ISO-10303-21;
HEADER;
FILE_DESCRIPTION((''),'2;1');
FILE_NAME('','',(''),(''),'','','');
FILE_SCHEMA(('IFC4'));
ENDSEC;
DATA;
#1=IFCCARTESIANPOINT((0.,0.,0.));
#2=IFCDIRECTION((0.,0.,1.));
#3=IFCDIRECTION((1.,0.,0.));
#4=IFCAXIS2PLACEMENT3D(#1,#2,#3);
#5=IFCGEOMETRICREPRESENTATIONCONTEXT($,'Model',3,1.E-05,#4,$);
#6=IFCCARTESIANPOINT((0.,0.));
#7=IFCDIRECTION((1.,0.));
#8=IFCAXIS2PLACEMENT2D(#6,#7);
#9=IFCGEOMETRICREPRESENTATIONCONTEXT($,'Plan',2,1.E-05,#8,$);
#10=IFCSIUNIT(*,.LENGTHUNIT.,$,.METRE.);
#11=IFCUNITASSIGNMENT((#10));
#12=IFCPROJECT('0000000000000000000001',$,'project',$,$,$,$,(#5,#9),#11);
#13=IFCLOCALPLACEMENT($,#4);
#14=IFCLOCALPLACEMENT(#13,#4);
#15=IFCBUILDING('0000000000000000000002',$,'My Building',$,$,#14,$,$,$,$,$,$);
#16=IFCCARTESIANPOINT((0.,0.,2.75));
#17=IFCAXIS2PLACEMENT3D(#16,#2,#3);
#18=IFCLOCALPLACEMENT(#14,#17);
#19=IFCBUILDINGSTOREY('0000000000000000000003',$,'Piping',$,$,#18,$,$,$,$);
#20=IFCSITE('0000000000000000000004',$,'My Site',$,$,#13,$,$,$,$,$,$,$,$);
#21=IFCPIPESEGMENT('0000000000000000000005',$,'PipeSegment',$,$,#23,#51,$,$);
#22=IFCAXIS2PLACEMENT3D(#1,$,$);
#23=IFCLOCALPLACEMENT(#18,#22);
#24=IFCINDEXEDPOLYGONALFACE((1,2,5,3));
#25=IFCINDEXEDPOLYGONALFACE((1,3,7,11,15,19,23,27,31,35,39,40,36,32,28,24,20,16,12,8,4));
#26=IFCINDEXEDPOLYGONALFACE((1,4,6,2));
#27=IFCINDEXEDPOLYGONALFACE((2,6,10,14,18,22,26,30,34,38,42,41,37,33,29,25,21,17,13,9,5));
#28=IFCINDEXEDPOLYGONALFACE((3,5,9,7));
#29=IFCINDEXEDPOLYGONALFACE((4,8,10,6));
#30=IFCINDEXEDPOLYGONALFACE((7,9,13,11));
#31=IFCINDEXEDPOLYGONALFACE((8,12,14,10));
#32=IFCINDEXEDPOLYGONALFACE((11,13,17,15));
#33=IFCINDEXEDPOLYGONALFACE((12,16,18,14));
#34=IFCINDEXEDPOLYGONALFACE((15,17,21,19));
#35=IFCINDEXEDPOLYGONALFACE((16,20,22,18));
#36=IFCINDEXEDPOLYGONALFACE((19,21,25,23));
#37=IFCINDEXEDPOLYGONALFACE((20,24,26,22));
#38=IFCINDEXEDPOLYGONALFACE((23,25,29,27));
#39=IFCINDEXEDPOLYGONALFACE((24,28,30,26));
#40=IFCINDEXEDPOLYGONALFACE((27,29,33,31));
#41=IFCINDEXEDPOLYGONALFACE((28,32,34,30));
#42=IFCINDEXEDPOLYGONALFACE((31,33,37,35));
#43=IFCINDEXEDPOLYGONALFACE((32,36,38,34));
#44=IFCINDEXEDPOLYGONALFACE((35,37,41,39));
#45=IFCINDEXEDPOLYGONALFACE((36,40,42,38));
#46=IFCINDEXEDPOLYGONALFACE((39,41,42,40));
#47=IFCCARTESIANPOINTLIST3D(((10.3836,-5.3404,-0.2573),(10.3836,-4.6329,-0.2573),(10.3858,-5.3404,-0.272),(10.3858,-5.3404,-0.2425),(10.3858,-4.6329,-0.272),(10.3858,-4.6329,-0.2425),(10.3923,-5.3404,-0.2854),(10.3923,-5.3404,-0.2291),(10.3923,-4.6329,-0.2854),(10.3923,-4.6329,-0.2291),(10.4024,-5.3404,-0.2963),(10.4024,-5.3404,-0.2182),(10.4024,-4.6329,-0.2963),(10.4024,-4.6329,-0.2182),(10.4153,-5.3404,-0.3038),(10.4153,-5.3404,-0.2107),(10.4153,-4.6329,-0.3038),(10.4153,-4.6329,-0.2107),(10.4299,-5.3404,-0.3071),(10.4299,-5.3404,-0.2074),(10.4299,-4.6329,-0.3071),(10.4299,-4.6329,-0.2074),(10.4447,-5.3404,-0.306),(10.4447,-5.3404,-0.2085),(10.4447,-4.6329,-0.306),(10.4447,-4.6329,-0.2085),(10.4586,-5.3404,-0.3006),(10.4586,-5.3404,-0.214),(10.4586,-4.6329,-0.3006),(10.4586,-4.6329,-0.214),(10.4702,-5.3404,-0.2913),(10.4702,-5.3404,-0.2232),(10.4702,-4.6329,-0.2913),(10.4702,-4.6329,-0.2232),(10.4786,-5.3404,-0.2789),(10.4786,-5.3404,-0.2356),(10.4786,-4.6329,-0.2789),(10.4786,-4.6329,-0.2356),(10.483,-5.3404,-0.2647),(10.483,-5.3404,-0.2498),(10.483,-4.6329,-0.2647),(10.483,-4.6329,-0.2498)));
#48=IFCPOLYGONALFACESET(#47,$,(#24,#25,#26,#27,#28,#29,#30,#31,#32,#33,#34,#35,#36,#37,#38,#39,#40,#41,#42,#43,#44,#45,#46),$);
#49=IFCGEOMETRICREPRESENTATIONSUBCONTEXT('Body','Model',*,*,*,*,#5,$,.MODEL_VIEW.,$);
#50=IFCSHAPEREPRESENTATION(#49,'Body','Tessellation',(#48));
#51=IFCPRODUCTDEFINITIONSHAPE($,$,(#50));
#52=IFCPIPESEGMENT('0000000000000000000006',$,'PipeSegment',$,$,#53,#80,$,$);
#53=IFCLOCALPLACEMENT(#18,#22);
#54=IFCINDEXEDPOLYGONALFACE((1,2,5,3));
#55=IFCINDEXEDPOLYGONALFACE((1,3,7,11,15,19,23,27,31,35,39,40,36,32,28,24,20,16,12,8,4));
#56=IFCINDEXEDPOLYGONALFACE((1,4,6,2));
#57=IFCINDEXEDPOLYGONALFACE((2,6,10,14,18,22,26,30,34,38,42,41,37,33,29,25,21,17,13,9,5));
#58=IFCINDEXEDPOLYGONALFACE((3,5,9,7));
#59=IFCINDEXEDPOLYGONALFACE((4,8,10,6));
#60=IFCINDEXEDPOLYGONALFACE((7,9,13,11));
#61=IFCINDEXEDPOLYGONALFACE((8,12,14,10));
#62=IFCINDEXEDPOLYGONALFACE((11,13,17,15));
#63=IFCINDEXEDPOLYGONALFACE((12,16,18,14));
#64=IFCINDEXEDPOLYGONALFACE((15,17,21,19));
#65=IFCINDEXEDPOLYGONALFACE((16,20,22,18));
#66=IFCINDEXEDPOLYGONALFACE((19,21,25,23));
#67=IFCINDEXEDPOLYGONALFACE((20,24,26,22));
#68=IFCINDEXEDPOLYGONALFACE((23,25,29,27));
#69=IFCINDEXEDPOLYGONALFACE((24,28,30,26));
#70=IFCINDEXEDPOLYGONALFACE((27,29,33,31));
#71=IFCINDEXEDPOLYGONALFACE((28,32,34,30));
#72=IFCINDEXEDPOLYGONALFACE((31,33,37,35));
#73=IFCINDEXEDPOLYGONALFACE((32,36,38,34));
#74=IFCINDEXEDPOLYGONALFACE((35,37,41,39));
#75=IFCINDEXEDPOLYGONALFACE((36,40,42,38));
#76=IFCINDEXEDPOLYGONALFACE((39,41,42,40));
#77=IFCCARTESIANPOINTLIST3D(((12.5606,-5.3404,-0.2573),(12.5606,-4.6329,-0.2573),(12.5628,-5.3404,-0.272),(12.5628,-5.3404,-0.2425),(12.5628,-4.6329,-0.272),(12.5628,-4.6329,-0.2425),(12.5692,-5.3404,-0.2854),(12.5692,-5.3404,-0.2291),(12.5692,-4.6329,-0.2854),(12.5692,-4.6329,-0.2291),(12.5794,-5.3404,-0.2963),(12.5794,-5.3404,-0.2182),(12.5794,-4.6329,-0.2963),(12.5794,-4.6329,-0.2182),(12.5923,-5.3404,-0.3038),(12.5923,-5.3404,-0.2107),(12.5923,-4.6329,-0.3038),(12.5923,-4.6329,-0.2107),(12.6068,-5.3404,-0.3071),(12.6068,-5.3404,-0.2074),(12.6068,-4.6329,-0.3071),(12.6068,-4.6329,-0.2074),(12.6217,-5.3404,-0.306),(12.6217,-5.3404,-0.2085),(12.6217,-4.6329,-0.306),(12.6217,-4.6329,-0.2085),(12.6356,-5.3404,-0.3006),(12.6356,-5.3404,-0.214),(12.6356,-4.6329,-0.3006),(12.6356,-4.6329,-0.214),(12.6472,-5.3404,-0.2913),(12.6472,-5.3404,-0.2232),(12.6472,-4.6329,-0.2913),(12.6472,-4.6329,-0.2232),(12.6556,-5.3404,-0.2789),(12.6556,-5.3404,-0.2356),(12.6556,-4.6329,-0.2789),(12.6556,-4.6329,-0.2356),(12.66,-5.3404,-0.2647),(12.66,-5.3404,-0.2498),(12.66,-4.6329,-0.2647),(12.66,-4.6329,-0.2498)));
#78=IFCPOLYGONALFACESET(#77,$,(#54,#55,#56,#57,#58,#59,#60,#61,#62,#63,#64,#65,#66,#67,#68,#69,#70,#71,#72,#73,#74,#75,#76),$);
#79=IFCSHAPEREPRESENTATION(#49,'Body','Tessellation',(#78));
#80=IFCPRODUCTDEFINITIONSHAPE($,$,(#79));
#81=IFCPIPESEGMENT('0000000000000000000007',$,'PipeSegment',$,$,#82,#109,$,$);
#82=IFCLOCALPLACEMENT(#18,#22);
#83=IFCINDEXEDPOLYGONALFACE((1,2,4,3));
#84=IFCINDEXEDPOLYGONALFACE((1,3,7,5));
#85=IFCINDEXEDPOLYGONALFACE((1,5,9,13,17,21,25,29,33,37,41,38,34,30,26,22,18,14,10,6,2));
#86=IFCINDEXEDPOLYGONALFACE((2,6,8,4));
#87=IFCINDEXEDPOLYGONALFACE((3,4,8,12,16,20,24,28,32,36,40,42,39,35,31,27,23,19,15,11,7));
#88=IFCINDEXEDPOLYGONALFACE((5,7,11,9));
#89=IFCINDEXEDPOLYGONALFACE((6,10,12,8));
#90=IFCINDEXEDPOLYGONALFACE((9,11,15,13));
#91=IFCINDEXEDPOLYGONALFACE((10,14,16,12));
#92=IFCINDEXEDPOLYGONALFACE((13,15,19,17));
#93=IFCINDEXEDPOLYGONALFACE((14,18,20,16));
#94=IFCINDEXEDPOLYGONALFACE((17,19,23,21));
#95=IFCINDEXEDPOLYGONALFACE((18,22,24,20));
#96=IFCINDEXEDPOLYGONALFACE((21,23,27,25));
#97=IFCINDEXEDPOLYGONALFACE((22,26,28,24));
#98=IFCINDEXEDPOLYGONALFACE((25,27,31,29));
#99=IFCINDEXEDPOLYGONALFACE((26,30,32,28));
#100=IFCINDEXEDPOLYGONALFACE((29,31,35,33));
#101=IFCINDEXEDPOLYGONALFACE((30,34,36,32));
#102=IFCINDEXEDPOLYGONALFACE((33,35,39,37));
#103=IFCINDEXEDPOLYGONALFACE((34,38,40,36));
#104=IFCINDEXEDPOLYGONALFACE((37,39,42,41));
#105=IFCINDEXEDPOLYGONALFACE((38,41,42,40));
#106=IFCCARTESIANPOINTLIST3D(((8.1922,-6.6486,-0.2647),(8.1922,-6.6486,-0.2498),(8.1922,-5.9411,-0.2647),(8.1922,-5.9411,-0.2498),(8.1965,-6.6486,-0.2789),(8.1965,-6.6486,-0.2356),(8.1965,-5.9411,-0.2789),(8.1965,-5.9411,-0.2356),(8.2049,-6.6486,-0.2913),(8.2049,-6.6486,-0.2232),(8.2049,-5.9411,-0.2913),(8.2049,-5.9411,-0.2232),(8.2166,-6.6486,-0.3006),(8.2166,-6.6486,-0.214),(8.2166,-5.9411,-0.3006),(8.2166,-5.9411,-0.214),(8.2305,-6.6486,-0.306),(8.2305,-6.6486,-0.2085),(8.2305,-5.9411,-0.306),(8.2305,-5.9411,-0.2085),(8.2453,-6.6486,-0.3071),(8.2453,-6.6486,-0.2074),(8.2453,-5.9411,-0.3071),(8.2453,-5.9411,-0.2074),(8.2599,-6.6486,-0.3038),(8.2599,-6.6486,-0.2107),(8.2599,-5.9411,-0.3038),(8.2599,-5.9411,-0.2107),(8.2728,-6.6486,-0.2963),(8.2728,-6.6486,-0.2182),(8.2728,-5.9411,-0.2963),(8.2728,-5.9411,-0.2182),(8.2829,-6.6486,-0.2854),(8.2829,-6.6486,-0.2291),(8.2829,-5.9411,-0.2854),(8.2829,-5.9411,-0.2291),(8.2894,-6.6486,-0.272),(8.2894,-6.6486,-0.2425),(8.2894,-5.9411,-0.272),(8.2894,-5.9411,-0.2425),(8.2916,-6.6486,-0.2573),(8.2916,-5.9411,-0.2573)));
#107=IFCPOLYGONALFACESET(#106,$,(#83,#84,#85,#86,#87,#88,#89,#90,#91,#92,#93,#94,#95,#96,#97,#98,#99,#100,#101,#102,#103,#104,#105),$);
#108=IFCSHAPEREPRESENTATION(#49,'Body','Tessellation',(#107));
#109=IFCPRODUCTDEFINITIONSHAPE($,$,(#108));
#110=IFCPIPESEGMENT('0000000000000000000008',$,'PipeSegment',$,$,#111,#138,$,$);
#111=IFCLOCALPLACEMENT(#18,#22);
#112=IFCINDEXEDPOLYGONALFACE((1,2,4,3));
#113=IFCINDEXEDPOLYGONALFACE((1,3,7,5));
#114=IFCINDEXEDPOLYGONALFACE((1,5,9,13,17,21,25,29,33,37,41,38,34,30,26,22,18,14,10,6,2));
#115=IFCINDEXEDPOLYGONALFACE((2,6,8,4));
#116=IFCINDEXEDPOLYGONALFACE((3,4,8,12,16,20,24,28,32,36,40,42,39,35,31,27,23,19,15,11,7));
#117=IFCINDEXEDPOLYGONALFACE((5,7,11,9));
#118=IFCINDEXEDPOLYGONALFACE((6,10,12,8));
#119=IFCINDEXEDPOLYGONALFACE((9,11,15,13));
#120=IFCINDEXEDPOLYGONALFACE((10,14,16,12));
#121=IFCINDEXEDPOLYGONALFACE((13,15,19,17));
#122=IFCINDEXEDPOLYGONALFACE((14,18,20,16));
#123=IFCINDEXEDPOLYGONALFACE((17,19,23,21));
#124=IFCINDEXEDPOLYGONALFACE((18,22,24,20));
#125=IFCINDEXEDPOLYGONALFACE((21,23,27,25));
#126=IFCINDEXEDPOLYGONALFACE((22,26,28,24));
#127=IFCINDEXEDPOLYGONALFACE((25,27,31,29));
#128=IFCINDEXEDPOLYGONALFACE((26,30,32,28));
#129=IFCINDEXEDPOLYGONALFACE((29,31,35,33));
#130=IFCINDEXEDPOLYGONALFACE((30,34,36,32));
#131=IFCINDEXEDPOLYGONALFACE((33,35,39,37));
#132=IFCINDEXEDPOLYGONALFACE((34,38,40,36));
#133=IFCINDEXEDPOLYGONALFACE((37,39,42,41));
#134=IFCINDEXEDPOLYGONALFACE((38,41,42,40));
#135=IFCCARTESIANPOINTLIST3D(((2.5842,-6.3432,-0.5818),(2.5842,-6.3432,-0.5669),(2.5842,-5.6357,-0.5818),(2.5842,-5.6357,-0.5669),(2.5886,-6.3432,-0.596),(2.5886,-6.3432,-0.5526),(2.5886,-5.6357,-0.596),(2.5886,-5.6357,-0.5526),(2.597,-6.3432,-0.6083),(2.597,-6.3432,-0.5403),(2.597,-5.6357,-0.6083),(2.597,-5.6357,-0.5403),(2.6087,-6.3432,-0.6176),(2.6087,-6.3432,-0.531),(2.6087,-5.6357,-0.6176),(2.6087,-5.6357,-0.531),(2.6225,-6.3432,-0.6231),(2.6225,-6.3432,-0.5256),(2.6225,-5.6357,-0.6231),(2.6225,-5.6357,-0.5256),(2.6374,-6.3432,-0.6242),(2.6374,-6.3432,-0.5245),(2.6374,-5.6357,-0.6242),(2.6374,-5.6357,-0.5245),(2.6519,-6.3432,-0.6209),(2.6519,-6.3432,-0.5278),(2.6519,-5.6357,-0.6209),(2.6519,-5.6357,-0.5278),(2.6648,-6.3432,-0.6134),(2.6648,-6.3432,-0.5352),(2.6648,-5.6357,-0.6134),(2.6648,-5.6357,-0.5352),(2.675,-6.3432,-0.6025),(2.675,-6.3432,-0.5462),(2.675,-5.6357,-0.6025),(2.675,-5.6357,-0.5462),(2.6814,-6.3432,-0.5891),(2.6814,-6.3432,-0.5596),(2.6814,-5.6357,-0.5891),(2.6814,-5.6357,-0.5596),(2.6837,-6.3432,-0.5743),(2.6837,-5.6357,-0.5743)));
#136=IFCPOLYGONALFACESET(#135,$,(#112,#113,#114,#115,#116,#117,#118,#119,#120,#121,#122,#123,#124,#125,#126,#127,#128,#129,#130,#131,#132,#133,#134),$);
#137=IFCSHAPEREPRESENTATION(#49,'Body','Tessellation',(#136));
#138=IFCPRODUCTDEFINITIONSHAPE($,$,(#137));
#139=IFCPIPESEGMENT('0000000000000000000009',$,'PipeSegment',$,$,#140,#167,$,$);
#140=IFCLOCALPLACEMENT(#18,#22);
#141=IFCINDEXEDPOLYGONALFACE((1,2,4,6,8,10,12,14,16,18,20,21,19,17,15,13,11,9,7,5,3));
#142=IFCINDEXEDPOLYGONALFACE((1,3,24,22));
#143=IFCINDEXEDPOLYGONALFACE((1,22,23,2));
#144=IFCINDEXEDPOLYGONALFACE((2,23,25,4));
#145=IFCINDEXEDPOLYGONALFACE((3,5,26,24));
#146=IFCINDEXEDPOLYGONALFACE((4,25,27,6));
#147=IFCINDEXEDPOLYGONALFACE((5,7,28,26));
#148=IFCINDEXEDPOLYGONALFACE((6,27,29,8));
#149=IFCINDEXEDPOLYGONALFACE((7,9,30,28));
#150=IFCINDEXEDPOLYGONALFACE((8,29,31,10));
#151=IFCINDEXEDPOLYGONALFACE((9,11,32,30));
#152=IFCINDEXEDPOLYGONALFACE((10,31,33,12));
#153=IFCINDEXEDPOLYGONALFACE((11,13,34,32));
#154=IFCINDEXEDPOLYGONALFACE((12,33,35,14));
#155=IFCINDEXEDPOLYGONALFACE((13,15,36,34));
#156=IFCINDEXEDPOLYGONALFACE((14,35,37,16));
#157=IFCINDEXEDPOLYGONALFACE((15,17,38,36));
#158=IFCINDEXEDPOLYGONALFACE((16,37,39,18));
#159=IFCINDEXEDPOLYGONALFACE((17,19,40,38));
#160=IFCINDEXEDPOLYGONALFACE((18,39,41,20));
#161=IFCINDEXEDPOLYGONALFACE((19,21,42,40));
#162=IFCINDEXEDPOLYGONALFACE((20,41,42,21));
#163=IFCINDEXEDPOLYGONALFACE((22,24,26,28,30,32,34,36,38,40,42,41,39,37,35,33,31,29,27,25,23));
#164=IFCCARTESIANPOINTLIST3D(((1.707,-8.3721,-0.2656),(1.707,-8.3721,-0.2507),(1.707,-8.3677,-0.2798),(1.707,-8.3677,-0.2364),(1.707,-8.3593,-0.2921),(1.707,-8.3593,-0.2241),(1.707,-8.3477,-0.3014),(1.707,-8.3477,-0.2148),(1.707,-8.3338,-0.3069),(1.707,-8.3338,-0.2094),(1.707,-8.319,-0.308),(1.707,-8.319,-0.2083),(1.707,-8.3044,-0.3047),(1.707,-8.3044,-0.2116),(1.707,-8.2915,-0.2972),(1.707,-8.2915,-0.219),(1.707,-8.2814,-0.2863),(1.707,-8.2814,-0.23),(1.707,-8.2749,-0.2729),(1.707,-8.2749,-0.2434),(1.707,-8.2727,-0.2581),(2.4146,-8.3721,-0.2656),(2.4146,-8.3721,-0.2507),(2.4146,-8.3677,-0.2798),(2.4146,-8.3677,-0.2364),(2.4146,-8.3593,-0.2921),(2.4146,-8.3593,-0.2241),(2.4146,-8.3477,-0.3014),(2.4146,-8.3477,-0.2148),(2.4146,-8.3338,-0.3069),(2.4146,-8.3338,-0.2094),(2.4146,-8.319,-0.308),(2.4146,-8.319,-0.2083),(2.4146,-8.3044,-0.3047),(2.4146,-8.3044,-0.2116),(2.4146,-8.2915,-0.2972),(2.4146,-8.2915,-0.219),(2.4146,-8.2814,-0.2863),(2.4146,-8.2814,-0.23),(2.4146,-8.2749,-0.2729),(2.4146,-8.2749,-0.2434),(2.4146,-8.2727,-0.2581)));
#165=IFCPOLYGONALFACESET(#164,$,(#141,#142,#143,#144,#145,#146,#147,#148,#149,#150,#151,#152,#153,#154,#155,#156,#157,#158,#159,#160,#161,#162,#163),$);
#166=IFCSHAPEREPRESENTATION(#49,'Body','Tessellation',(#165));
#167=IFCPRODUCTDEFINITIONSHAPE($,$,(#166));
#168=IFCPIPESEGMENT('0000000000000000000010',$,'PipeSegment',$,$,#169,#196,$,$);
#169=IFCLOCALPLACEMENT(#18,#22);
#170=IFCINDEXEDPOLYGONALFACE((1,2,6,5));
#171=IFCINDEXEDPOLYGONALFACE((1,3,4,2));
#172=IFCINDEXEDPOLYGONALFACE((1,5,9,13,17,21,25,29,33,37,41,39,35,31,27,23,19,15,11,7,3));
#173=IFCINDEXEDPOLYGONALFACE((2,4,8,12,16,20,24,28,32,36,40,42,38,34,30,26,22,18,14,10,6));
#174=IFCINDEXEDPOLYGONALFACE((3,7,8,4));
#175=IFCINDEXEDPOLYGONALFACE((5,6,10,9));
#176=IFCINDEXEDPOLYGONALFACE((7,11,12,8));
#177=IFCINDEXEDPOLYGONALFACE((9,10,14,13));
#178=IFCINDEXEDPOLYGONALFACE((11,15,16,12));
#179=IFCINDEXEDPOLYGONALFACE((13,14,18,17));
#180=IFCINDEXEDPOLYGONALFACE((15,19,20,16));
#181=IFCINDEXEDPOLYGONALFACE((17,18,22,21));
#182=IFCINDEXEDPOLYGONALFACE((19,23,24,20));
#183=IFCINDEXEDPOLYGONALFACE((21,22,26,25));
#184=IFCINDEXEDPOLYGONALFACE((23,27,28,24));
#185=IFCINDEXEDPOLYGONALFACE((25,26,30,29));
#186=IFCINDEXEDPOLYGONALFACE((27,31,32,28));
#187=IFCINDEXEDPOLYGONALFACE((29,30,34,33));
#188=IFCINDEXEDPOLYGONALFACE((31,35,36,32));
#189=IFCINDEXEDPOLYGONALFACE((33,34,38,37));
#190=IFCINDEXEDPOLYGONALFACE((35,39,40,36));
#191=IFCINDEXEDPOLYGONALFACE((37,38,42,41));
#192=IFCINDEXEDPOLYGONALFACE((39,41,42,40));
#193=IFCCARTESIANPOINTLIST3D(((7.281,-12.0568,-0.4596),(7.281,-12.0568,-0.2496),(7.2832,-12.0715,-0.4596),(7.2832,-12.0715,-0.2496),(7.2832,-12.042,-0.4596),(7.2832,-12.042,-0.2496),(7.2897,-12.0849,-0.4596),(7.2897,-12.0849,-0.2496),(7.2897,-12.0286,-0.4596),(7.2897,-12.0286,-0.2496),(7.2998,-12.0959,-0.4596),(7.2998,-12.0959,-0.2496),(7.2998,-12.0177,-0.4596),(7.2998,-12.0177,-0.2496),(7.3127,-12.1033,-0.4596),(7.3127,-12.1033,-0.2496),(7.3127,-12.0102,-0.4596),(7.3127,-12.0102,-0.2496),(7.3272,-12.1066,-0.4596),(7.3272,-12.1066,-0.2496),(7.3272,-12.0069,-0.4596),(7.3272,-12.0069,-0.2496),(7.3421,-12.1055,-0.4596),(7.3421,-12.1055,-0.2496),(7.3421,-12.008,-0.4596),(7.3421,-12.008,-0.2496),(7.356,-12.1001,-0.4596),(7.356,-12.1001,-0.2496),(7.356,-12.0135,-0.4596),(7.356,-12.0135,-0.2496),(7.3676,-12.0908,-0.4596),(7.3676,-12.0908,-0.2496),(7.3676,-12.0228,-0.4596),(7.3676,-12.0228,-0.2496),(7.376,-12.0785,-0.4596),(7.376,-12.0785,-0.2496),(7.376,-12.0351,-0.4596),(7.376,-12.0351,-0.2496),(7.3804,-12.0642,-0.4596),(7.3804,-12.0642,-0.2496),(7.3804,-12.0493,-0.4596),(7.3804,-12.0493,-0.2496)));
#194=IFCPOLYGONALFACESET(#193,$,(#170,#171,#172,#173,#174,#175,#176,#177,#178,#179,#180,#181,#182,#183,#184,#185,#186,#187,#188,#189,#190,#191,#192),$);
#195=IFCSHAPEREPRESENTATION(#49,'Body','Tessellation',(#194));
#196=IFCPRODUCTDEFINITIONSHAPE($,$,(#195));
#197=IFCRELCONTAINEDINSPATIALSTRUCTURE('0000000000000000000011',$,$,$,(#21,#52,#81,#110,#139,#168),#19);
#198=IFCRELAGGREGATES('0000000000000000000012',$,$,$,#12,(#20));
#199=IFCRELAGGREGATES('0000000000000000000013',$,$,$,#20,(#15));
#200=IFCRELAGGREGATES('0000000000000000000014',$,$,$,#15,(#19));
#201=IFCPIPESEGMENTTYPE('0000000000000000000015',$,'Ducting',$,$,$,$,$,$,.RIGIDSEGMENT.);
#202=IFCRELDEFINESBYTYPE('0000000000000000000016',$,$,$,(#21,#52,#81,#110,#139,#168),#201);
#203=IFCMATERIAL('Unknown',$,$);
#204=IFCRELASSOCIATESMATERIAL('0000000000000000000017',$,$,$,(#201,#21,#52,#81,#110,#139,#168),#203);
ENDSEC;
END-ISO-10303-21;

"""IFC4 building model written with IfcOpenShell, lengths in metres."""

from ifc_helpers import new_model, si_unit, frame, origin_with_axes, origin_2d_with_axis, place, context, subcontext, project, spatial, circle, extrude, material, material_profile, profile_set, profile_usage, type_object, element, save


model = new_model("IFC4")

# Units and contexts
model_context = context("Model", 3, precision=1e-05, world=origin_with_axes())
plan_context = context("Plan", 2, precision=1e-05, world=origin_2d_with_axis())
body_context = subcontext(model_context, "Body", "Model", "MODEL_VIEW")
ifc_project = project(units=[si_unit("LENGTHUNIT", "METRE")], contexts=[model_context, plan_context])

# Site, building, storey
site_placement = place(None, origin_with_axes())
site = spatial("IfcSite", under=ifc_project, at=site_placement, Name="My Site")
building_placement = place(site_placement, origin_with_axes())
building = spatial("IfcBuilding", under=site, at=building_placement, Name="My Building")
storey_placement = place(building_placement, frame((0.0, 0.0, 2.75), z_axis=(0.0, 0.0, 1.0), x_axis=(1.0, 0.0, 0.0)))
storey = spatial("IfcBuildingStorey", under=building, at=storey_placement, Name="Piping")

# Pipe segments
ifc_material = material(Name="Unknown")
ifc_material_profile = material_profile(ifc_material, circle(Radius=0.05))
ifc_profile_set = profile_set([ifc_material_profile])
pipe_segment_type = type_object("IfcPipeSegmentType", Name="Ducting", PredefinedType="RIGIDSEGMENT", material=ifc_profile_set)
ifc_profile_usage_1 = profile_usage(ifc_profile_set, cardinal=4)
pipe_segment_1_placement = place(storey_placement, frame((10.3836, -5.3404, -0.2573), z_axis=(0.0, 1.0, 0.0), x_axis=(-1.0, 0.0, 0.0)))
element("IfcPipeSegment", 1, at=pipe_segment_1_placement, inside=storey, type_object=pipe_segment_type, material=ifc_profile_usage_1, Name="PipeSegment", context=body_context, shape_type="SweptSolid", body=[
    extrude(circle(Radius=0.05), frame((-0.05, 0.0, 0.0), z_axis=(0.0, 0.0, 1.0), x_axis=(1.0, 0.0, 0.0)), (0.0, 0.0, 1.0), 0.7075),
])
ifc_profile_usage_2 = profile_usage(ifc_profile_set, cardinal=4)
pipe_segment_2_placement = place(storey_placement, frame((12.5606, -5.3404, -0.2573), z_axis=(0.0, 1.0, 0.0), x_axis=(-1.0, 0.0, 0.0)))
element("IfcPipeSegment", 2, at=pipe_segment_2_placement, inside=storey, type_object=pipe_segment_type, material=ifc_profile_usage_2, Name="PipeSegment", context=body_context, shape_type="SweptSolid", body=[
    extrude(circle(Radius=0.05), frame((-0.05, 0.0, 0.0), z_axis=(0.0, 0.0, 1.0), x_axis=(1.0, 0.0, 0.0)), (0.0, 0.0, 1.0), 0.7075),
])
ifc_profile_usage_3 = profile_usage(ifc_profile_set, cardinal=4)
pipe_segment_3_placement = place(storey_placement, frame((8.2916, -5.9411, -0.2573), z_axis=(0.0, -1.0, 0.0), x_axis=(1.0, 0.0, 0.0)))
element("IfcPipeSegment", 3, at=pipe_segment_3_placement, inside=storey, type_object=pipe_segment_type, material=ifc_profile_usage_3, Name="PipeSegment", context=body_context, shape_type="SweptSolid", body=[
    extrude(circle(Radius=0.05), frame((-0.05, 0.0, 0.0), z_axis=(0.0, 0.0, 1.0), x_axis=(1.0, 0.0, 0.0)), (0.0, 0.0, 1.0), 0.7075),
])
ifc_profile_usage_4 = profile_usage(ifc_profile_set, cardinal=4)
pipe_segment_4_placement = place(storey_placement, frame((2.6837, -5.6357, -0.5743), z_axis=(0.0, -1.0, 0.0), x_axis=(1.0, 0.0, 0.0)))
element("IfcPipeSegment", 4, at=pipe_segment_4_placement, inside=storey, type_object=pipe_segment_type, material=ifc_profile_usage_4, Name="PipeSegment", context=body_context, shape_type="SweptSolid", body=[
    extrude(circle(Radius=0.05), frame((-0.05, 0.0, 0.0), z_axis=(0.0, 0.0, 1.0), x_axis=(1.0, 0.0, 0.0)), (0.0, 0.0, 1.0), 0.7075),
])
ifc_profile_usage_5 = profile_usage(ifc_profile_set, cardinal=4)
pipe_segment_5_placement = place(storey_placement, frame((1.707, -8.2727, -0.2581), z_axis=(1.0, 0.0, 0.0), x_axis=(0.0, 1.0, 0.0)))
element("IfcPipeSegment", 5, at=pipe_segment_5_placement, inside=storey, type_object=pipe_segment_type, material=ifc_profile_usage_5, Name="PipeSegment", context=body_context, shape_type="SweptSolid", body=[
    extrude(circle(Radius=0.05), frame((-0.05, 0.0, 0.0), z_axis=(0.0, 0.0, 1.0), x_axis=(1.0, 0.0, 0.0)), (0.0, 0.0, 1.0), 0.7075),
])
ifc_profile_usage_6 = profile_usage(ifc_profile_set, cardinal=4)
pipe_segment_6_placement = place(storey_placement, frame((7.281, -12.0568, -0.2496), z_axis=(0.0, 0.0, -1.0), x_axis=(-1.0, 0.0, 0.0)))
element("IfcPipeSegment", 6, at=pipe_segment_6_placement, inside=storey, type_object=pipe_segment_type, material=ifc_profile_usage_6, Name="PipeSegment", context=body_context, shape_type="SweptSolid", body=[
    extrude(circle(Radius=0.05), frame((-0.05, 0.0, 0.0), z_axis=(0.0, 0.0, 1.0), x_axis=(1.0, 0.0, 0.0)), (0.0, 0.0, 1.0), 0.21),
])

save(model, "model.ifc")
